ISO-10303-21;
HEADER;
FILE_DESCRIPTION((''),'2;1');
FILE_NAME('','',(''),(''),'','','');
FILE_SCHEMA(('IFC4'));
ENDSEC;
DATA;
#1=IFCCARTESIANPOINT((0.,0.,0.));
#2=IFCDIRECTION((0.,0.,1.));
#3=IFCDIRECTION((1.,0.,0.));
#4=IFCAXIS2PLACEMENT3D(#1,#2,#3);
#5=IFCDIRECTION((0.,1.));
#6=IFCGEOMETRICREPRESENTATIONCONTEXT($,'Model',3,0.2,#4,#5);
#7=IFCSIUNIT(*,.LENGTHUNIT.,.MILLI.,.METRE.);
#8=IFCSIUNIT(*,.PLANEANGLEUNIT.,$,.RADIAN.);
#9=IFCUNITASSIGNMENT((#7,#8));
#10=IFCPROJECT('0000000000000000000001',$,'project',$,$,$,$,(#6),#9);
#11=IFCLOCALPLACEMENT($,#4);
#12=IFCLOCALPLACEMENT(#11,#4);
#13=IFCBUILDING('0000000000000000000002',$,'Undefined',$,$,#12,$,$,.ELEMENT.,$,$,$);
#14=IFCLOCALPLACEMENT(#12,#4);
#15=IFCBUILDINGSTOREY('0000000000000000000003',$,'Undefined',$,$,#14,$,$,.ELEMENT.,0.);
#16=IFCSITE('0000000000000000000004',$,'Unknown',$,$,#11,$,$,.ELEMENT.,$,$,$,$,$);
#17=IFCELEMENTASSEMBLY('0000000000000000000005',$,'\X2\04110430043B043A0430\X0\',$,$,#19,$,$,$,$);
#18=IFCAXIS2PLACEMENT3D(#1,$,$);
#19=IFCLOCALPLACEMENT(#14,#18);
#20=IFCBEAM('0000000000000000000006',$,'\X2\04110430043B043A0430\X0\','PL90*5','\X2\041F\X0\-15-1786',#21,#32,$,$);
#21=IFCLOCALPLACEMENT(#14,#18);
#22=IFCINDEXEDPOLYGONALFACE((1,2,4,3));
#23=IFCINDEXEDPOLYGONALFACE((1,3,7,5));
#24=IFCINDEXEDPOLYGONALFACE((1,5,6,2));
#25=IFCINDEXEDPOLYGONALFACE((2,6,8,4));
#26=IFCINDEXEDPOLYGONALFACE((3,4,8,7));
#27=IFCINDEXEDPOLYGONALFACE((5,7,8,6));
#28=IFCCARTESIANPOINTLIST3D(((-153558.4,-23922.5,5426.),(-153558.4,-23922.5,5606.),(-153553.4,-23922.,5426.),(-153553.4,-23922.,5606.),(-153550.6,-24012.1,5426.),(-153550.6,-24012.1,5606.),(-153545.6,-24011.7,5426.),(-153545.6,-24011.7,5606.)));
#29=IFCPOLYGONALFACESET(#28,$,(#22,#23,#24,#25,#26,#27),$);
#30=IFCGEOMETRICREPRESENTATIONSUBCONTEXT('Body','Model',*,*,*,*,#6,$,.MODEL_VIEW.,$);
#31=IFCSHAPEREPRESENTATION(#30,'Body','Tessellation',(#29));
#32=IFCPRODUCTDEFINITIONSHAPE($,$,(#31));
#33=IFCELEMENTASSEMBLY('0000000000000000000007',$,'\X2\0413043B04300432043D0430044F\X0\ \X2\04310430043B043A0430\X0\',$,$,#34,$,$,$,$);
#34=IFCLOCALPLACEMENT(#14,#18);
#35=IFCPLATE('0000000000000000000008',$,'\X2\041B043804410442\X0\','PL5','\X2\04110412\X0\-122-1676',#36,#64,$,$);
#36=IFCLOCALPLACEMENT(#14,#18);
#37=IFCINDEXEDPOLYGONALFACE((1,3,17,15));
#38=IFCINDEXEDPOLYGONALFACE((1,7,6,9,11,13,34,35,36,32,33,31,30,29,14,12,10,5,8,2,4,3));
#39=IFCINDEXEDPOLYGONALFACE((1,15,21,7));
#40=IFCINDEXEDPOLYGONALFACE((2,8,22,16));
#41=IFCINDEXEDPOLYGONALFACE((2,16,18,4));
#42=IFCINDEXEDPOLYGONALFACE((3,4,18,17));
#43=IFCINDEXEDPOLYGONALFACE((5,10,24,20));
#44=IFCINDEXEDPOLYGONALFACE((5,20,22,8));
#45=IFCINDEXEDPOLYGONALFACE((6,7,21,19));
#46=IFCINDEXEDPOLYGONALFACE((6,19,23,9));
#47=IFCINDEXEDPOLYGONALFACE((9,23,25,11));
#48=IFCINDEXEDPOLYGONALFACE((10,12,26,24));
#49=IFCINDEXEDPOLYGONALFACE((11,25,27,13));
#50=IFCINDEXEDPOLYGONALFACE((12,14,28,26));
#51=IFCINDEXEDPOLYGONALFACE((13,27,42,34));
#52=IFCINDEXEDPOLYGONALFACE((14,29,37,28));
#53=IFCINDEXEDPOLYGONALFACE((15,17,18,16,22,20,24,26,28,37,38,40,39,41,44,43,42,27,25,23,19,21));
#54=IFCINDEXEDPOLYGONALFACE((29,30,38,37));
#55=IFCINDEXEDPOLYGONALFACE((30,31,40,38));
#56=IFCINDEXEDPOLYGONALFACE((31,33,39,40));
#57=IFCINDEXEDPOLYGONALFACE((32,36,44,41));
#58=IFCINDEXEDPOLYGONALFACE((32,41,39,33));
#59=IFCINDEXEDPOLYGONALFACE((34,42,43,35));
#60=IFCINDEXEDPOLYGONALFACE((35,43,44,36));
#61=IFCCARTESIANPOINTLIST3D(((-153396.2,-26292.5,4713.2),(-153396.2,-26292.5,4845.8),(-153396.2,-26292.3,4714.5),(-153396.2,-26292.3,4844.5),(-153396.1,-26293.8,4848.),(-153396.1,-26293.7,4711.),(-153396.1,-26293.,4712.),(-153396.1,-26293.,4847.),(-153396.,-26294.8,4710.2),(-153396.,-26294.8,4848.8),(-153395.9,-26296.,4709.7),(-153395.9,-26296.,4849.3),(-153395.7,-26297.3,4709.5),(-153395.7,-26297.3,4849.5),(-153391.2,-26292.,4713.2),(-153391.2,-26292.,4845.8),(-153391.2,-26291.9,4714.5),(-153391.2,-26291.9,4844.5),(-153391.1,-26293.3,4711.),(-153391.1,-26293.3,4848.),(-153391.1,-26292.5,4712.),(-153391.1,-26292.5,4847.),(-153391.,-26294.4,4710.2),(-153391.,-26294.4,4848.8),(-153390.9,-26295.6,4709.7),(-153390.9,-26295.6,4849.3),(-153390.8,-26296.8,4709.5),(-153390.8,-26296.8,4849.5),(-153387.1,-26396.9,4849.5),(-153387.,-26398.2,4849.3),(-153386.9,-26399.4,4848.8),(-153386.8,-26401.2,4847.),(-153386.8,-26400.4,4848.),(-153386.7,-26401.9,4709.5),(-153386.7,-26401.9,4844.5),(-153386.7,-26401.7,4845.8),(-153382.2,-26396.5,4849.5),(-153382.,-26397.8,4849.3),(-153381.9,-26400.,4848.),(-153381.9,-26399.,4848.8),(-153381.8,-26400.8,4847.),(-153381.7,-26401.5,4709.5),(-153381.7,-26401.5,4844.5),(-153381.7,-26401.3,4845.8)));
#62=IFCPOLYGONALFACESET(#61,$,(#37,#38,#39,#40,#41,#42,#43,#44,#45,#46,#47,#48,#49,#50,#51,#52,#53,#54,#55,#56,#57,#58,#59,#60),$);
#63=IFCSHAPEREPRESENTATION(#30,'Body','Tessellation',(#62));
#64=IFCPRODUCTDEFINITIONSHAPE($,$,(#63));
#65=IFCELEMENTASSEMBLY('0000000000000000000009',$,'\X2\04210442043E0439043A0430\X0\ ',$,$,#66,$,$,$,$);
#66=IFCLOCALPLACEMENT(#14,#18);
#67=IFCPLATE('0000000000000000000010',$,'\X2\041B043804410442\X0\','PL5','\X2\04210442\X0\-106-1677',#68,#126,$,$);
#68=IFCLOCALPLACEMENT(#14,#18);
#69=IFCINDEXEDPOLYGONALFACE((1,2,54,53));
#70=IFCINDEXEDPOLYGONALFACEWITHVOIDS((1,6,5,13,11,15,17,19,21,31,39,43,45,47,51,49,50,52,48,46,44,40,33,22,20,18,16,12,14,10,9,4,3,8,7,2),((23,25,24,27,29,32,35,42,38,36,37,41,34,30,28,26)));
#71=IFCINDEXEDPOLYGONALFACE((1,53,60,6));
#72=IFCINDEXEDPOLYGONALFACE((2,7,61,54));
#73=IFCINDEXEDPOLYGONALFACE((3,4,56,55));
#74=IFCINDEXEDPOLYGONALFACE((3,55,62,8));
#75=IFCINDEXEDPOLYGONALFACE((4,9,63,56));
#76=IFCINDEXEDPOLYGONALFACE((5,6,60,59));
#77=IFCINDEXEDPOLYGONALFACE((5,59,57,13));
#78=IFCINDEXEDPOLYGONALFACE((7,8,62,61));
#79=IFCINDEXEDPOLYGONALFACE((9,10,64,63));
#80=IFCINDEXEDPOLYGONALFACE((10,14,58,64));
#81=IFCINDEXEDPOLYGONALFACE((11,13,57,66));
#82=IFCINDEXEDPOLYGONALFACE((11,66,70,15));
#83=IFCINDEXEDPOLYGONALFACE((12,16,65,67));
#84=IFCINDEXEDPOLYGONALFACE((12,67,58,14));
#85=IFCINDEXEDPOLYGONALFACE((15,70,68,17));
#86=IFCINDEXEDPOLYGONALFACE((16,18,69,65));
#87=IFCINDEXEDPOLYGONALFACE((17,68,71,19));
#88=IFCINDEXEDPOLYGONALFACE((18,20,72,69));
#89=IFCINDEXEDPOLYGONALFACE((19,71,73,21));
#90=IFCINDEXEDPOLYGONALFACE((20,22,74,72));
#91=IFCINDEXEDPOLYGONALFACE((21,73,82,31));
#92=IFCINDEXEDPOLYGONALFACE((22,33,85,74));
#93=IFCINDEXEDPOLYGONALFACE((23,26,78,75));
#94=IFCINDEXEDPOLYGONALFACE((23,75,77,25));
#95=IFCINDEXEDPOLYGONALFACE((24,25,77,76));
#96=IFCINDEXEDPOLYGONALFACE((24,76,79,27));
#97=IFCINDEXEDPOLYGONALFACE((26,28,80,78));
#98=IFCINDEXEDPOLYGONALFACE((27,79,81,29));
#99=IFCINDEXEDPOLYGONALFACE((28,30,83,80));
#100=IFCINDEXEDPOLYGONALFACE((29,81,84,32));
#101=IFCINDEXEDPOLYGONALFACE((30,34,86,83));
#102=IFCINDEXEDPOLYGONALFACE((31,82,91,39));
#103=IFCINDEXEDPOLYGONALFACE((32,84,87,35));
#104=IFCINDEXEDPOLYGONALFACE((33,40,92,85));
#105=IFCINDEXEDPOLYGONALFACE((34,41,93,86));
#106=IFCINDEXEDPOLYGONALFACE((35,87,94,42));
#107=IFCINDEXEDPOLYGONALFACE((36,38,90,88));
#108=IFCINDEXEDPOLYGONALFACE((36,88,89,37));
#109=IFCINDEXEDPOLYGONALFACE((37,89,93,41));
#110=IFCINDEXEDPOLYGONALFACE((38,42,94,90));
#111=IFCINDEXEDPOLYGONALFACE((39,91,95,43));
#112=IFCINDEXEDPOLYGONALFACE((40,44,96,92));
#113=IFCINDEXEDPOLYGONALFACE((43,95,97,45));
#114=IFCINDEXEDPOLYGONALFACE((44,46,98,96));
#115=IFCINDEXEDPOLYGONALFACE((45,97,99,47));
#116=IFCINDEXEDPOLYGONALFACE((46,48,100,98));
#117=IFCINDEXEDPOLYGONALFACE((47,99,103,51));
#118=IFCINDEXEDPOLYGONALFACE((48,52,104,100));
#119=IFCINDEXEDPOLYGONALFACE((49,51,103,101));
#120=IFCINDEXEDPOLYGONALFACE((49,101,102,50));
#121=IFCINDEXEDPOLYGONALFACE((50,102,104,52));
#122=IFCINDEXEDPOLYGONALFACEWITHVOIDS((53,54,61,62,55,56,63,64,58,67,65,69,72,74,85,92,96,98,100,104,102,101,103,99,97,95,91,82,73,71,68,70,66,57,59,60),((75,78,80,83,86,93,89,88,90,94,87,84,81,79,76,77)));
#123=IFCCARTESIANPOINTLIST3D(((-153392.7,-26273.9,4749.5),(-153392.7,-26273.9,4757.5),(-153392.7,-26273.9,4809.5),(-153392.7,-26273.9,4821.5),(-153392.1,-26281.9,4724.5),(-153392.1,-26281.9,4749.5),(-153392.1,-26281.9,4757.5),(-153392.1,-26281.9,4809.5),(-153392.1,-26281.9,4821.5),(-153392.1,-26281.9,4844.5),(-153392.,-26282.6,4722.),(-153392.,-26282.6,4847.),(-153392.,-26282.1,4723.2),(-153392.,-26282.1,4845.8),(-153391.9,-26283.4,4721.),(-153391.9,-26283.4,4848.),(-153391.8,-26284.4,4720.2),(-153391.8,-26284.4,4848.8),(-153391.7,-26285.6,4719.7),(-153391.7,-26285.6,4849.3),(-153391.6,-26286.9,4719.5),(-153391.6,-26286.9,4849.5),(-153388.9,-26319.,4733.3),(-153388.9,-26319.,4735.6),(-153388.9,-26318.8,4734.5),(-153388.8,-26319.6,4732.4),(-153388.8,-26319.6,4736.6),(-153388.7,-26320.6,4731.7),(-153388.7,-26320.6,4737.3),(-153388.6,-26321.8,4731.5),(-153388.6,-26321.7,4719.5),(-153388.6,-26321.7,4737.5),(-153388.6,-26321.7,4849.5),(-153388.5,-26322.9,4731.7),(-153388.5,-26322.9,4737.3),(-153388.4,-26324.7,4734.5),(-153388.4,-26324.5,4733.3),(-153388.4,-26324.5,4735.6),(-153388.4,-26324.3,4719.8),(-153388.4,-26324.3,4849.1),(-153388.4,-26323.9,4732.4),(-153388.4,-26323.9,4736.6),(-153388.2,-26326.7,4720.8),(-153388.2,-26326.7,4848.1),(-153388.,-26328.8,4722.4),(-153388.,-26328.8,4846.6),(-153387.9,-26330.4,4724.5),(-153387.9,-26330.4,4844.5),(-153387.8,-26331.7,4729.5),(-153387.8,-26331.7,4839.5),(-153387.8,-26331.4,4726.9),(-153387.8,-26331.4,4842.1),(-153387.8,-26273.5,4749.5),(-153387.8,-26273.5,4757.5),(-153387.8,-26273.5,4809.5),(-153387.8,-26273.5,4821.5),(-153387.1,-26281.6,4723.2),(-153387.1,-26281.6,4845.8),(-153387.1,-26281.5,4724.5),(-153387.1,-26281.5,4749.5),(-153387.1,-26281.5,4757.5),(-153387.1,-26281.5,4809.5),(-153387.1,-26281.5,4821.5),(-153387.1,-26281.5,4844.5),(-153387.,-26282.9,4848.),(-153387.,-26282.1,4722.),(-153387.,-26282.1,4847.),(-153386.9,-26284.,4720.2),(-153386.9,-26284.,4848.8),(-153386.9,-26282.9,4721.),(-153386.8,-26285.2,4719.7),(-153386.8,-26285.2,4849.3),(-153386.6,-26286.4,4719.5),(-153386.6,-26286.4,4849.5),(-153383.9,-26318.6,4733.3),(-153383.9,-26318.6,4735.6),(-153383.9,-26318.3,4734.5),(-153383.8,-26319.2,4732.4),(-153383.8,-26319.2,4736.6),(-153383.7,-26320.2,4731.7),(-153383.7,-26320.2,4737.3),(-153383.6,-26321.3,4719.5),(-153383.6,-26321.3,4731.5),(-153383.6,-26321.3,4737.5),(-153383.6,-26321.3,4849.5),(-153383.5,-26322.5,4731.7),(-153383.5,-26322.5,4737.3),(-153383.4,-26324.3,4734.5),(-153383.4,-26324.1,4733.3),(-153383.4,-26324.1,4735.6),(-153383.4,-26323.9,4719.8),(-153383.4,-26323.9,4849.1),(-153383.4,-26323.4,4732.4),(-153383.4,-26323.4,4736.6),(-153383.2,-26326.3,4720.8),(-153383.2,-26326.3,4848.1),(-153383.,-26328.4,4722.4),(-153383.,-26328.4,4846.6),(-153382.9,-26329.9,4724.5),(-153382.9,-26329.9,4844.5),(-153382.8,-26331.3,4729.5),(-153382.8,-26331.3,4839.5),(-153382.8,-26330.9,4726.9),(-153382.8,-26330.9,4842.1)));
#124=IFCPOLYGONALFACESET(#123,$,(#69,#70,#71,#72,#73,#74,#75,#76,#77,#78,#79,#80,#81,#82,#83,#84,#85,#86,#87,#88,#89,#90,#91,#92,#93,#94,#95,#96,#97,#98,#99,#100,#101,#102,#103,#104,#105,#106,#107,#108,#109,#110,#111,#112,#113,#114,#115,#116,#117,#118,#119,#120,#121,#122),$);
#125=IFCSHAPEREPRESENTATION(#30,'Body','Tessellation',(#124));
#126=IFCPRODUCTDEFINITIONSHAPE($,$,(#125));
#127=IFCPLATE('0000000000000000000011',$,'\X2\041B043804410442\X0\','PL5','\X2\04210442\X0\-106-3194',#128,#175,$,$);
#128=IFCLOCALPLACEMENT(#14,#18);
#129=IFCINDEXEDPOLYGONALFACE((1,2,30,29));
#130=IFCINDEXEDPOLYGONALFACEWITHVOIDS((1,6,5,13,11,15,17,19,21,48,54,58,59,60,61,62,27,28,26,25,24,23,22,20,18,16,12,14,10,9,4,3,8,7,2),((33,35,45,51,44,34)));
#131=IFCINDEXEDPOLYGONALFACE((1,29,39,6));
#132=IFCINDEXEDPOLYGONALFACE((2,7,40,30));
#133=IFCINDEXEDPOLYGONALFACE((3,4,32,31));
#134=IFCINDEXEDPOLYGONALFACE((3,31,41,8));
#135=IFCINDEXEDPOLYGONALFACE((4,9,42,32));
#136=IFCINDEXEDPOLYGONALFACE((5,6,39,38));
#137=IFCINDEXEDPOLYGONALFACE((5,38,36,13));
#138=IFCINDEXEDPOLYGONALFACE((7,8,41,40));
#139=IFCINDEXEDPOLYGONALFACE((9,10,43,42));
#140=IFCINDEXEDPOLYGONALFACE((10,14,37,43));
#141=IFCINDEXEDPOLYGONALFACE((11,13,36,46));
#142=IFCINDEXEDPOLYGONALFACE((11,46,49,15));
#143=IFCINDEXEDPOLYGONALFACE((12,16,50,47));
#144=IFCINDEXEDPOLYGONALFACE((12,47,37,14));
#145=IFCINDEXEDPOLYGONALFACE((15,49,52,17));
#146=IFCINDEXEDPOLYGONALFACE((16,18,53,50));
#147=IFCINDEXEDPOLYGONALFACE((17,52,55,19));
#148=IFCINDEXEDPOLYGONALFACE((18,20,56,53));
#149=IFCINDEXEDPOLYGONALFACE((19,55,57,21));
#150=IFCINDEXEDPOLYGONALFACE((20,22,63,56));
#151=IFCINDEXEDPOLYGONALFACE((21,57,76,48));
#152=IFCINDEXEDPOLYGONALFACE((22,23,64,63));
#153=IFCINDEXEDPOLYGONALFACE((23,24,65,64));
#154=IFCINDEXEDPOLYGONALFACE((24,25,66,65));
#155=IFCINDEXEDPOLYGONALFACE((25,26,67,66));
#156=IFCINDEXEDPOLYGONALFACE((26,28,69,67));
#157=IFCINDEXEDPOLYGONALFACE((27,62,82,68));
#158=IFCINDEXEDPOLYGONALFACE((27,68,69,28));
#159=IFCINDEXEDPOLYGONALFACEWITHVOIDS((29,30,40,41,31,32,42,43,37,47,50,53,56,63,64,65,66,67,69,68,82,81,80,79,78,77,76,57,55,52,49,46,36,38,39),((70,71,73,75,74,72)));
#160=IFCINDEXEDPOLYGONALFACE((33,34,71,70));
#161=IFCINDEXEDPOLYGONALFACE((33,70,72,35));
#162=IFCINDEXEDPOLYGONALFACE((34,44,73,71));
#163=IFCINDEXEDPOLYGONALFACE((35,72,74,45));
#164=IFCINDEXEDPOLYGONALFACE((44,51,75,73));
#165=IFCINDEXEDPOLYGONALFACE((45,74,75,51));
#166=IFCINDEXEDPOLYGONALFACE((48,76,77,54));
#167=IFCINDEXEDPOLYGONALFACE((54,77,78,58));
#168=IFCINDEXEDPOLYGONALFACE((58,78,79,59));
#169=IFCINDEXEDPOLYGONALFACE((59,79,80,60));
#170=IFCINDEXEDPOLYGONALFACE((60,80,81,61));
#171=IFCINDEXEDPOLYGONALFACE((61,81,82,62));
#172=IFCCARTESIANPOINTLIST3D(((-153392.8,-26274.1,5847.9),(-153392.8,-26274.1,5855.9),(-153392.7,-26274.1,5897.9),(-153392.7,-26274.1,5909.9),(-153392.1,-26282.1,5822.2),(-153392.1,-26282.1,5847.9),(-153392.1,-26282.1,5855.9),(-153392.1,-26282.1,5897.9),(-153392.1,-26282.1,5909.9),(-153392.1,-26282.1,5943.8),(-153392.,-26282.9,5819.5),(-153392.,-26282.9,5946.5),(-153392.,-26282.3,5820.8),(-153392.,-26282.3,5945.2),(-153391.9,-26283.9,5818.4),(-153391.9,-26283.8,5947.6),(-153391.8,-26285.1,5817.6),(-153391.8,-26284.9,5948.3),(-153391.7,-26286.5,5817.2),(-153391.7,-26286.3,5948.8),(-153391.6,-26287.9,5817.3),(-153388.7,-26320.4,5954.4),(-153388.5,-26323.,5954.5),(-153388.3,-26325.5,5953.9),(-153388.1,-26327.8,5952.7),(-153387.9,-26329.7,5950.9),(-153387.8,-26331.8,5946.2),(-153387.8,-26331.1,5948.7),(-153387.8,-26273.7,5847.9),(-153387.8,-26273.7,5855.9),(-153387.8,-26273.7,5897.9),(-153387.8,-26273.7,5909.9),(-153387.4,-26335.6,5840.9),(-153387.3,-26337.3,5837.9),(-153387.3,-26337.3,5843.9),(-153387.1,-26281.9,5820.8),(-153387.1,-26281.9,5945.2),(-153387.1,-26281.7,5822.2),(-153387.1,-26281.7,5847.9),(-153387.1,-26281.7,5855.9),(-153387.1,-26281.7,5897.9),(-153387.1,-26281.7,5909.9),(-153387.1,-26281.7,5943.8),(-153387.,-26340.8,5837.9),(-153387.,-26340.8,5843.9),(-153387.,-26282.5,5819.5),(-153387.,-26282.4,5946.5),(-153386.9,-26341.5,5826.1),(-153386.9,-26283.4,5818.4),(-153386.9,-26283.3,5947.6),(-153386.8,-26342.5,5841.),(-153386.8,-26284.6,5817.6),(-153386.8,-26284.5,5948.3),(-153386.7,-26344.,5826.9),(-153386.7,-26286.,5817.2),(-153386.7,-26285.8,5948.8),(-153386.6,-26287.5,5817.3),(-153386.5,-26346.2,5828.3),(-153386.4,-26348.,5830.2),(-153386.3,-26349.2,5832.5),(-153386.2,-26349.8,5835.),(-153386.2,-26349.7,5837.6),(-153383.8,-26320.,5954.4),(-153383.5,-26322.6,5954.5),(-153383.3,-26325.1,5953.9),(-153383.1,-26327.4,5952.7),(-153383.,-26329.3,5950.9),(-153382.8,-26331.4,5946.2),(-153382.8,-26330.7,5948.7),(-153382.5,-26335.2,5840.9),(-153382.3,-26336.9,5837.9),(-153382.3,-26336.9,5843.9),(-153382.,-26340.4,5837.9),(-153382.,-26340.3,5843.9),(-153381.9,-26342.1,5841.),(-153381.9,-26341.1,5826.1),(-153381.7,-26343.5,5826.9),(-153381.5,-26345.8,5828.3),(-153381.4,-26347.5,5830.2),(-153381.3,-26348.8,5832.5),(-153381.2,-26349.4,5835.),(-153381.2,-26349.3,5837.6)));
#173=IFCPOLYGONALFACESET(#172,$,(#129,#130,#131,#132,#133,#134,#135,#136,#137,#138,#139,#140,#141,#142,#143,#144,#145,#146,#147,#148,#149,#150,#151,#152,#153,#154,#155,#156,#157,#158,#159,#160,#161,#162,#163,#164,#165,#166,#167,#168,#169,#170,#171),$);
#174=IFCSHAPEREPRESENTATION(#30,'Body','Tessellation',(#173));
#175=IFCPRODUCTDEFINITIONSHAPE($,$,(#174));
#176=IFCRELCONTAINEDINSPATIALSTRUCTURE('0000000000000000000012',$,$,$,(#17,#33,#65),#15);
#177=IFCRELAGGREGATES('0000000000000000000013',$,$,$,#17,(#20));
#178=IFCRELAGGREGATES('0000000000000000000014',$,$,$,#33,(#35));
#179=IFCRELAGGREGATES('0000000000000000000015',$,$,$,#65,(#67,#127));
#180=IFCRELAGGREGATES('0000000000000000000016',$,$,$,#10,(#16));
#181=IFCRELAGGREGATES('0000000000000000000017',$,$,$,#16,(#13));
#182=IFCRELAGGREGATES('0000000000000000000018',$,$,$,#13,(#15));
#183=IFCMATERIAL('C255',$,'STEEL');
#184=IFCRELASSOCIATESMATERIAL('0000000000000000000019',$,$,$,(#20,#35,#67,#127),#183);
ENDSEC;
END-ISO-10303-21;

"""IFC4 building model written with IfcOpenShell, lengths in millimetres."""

from ifc_helpers import new_model, si_unit, direction, frame, origin_with_axes, place, context, subcontext, project, spatial, line, arc, indexed_curve, outline, extrude, material, element, aggregate, save


model = new_model("IFC4")

# Units and contexts
model_context = context("Model", 3, precision=0.2, world=origin_with_axes(), true_north=direction((0.0, 1.0)))
body_context = subcontext(model_context, "Body", "Model", "MODEL_VIEW")
ifc_project = project(units=[si_unit("LENGTHUNIT", "METRE", prefix="MILLI"), si_unit("PLANEANGLEUNIT", "RADIAN")], contexts=[model_context])

# Site, building, storey
site_placement = place(None, origin_with_axes())
site = spatial("IfcSite", under=ifc_project, at=site_placement, Name="Unknown", CompositionType="ELEMENT")
building_placement = place(site_placement, origin_with_axes())
building = spatial("IfcBuilding", under=site, at=building_placement, Name="Undefined", CompositionType="ELEMENT")
storey_placement = place(building_placement, origin_with_axes())
storey = spatial("IfcBuildingStorey", under=building, at=storey_placement, Name="Undefined", CompositionType="ELEMENT", Elevation=0.0)

# Element assembly, beam
assembly_1_placement = place(storey_placement, frame((-153552.0, -23967.1, 5606.0), z_axis=(0.996285, 0.086114, 0.0), x_axis=(0.0, 0.0, -1.0)))
assembly_1 = element("IfcElementAssembly", 1, at=assembly_1_placement, inside=storey, Name="Балка")
ifc_material_1 = material(Name="C255", Category="STEEL")
beam_placement = place(assembly_1_placement, origin_with_axes())
beam = element("IfcBeam", 2, at=beam_placement, material=ifc_material_1, Name="Балка", Description="PL90*5", ObjectType="П-15-1786", context=body_context, shape_type="SolidModel", body=[
    extrude(outline(indexed_curve([(-2.5, -45.0), (2.5, -45.0), (2.5, 45.0), (-2.5, 45.0)], segments=[line(1, 2, 3, 4, 1)])), frame((0.0, 0.0, 0.0), z_axis=(-1.0, 0.0, 0.0), x_axis=(0.0, 0.0, 1.0)), (0.0, 0.0, -1.0), 180.0),
])
aggregate(assembly_1, [beam])

# Element assembly, plate
assembly_2_placement = place(storey_placement, frame((-153222.7, -28270.2, 4779.5), z_axis=(-0.996286, -0.086101, -0.000024), x_axis=(-0.086101, 0.996286, 0.0)))
assembly_2 = element("IfcElementAssembly", 3, at=assembly_2_placement, inside=storey, Name="Главная балка")
plate_1_placement = place(assembly_2_placement, frame((1985.5, -70.0, 0.0), z_axis=(0.0, 0.0, 1.0), x_axis=(0.0, 1.0, 0.0)))
plate_1 = element("IfcPlate", 4, at=plate_1_placement, material=ifc_material_1, Name="Лист", Description="PL5", ObjectType="БВ-122-1676", context=body_context, shape_type="SolidModel", body=[
    extrude(outline(indexed_curve([(0.0, 5.0), (1.5, 1.5), (5.0, 0.0), (135.0, 0.0), (138.5, 1.5), (140.0, 5.0), (140.0, 110.0), (5.0, 110.0), (1.5, 108.5), (0.0, 105.0)], segments=[arc(1, 2, 3), line(3, 4), arc(4, 5, 6), line(6, 7, 8), arc(8, 9, 10), line(10, 1)])), frame((0.0, 0.0, 2.5), z_axis=(0.0, 0.0, 1.0), x_axis=(1.0, 0.0, 0.0)), (0.0, 0.0, -1.0), 5.0),
])

# Element assembly, plates, voiding features
assembly_3_placement = place(storey_placement, frame((-153388.9, -26231.4, 4198.4), z_axis=(-0.086114, 0.996285, 0.0), x_axis=(0.0, 0.0, 1.0)))
assembly_3 = element("IfcElementAssembly", 5, at=assembly_3_placement, inside=storey, Name="Стойка ")
plate_2_placement = place(assembly_3_placement, frame((521.1, -5.0, -100.0), z_axis=(-0.000024, -1.0, 0.000013), x_axis=(1.0, -0.000024, 0.0)))
plate_2 = element("IfcPlate", 6, at=plate_2_placement, material=ifc_material_1, Name="Лист", Description="PL5", ObjectType="Ст-106-1677", context=body_context, shape_type="SolidModel", body=[
    extrude(outline(indexed_curve([(0.0, 10.0), (2.9, 2.9), (10.0, 0.0), (120.0, 0.0), (127.1, 2.9), (130.0, 10.0), (130.0, 45.0), (128.5, 48.5), (125.0, 50.0), (102.0, 50.0), (102.0, 58.0), (90.0, 58.0), (90.0, 50.0), (38.0, 50.0), (38.0, 58.0), (30.0, 58.0), (30.0, 50.0), (5.0, 50.0), (1.5, 48.5), (0.0, 45.0)], segments=[arc(1, 2, 3), line(3, 4), arc(4, 5, 6), line(6, 7), arc(7, 8, 9), line(9, 10, 11, 12, 13, 14, 15, 16, 17, 18), arc(18, 19, 20), line(20, 1)])), frame((0.0, 0.0, 2.5), z_axis=(0.0, 0.0, 1.0), x_axis=(1.0, 0.0, 0.0)), (0.0, 0.0, -1.0), 5.0),
])
voiding_feature_1_placement = place(plate_2_placement, frame((15.0, 10.0, 10.0), z_axis=(0.003022, -0.999995, 0.0), x_axis=(0.0, 0.0, -1.0)))
element("IfcVoidingFeature", 7, at=voiding_feature_1_placement, cuts=plate_2, Name="Балка", ObjectType="(?)", PredefinedType="HOLE", context=body_context, shape_type="SolidModel", body=[
    extrude(outline(indexed_curve([(3.0, 0.0), (2.8, 1.1), (2.1, 2.1), (1.1, 2.8), (0.0, 3.0), (-1.1, 2.8), (-2.1, 2.1), (-2.8, 1.1), (-3.0, 0.0), (-2.8, -1.1), (-2.1, -2.1), (-1.1, -2.8), (0.0, -3.0), (1.1, -2.8), (2.1, -2.1), (2.8, -1.1)], segments=[line(1, 2, 3, 4, 5, 6, 7, 8, 9, 10, 11, 12, 13, 14, 15, 16, 1)])), frame((0.0, 0.0, 0.0), z_axis=(-1.0, 0.0, 0.0), x_axis=(0.0, 0.0, 1.0)), (0.0, 0.0, -1.0), 20.0),
])
plate_3_placement = place(assembly_3_placement, frame((1629.4, -5.0, -119.7), z_axis=(0.000023, -1.0, 0.000007), x_axis=(0.986646, 0.000024, 0.162881)))
plate_3 = element("IfcPlate", 8, at=plate_3_placement, material=ifc_material_1, Name="Лист", Description="PL5", ObjectType="Ст-106-3194", context=body_context, shape_type="SolidModel", body=[
    extrude(outline(indexed_curve([(0.0, 10.0), (2.9, 2.9), (10.0, 0.0), (120.0, 0.0), (127.1, 2.9), (130.0, 10.0), (130.0, 44.7), (128.8, 48.0), (125.8, 49.6), (92.4, 55.2), (93.7, 63.1), (81.9, 65.0), (80.6, 57.1), (39.1, 64.0), (40.4, 71.9), (32.5, 73.2), (31.2, 65.3), (5.8, 69.5), (1.8, 68.3), (0.0, 64.5)], segments=[arc(1, 2, 3), line(3, 4), arc(4, 5, 6), line(6, 7), arc(7, 8, 9), line(9, 10, 11, 12, 13, 14, 15, 16, 17, 18), arc(18, 19, 20), line(20, 1)])), frame((0.0, 0.0, 2.5), z_axis=(0.0, 0.0, 1.0), x_axis=(1.0, 0.0, 0.0)), (0.0, 0.0, -1.0), 5.0),
])
voiding_feature_2_placement = place(plate_3_placement, frame((15.0, 10.0, 10.0), z_axis=(-0.159897, -0.987134, 0.0), x_axis=(0.0, 0.0, -1.0)))
element("IfcVoidingFeature", 9, at=voiding_feature_2_placement, cuts=plate_3, Name="Балка", ObjectType="(?)", PredefinedType="HOLE", context=body_context, shape_type="SolidModel", body=[
    extrude(outline(indexed_curve([(1.7, -3.0), (3.5, 0.0), (1.7, 3.0), (-1.7, 3.0), (-3.5, 0.0), (-1.7, -3.0)], segments=[line(1, 2, 3, 4, 5, 6, 1)])), frame((0.0, 0.0, 0.0), z_axis=(-1.0, 0.0, 0.0), x_axis=(0.0, 0.0, 1.0)), (0.0, 0.0, -1.0), 20.0),
])

aggregate(assembly_2, [plate_1])

aggregate(assembly_3, [plate_2, plate_3])

save(model, "model.ifc")
